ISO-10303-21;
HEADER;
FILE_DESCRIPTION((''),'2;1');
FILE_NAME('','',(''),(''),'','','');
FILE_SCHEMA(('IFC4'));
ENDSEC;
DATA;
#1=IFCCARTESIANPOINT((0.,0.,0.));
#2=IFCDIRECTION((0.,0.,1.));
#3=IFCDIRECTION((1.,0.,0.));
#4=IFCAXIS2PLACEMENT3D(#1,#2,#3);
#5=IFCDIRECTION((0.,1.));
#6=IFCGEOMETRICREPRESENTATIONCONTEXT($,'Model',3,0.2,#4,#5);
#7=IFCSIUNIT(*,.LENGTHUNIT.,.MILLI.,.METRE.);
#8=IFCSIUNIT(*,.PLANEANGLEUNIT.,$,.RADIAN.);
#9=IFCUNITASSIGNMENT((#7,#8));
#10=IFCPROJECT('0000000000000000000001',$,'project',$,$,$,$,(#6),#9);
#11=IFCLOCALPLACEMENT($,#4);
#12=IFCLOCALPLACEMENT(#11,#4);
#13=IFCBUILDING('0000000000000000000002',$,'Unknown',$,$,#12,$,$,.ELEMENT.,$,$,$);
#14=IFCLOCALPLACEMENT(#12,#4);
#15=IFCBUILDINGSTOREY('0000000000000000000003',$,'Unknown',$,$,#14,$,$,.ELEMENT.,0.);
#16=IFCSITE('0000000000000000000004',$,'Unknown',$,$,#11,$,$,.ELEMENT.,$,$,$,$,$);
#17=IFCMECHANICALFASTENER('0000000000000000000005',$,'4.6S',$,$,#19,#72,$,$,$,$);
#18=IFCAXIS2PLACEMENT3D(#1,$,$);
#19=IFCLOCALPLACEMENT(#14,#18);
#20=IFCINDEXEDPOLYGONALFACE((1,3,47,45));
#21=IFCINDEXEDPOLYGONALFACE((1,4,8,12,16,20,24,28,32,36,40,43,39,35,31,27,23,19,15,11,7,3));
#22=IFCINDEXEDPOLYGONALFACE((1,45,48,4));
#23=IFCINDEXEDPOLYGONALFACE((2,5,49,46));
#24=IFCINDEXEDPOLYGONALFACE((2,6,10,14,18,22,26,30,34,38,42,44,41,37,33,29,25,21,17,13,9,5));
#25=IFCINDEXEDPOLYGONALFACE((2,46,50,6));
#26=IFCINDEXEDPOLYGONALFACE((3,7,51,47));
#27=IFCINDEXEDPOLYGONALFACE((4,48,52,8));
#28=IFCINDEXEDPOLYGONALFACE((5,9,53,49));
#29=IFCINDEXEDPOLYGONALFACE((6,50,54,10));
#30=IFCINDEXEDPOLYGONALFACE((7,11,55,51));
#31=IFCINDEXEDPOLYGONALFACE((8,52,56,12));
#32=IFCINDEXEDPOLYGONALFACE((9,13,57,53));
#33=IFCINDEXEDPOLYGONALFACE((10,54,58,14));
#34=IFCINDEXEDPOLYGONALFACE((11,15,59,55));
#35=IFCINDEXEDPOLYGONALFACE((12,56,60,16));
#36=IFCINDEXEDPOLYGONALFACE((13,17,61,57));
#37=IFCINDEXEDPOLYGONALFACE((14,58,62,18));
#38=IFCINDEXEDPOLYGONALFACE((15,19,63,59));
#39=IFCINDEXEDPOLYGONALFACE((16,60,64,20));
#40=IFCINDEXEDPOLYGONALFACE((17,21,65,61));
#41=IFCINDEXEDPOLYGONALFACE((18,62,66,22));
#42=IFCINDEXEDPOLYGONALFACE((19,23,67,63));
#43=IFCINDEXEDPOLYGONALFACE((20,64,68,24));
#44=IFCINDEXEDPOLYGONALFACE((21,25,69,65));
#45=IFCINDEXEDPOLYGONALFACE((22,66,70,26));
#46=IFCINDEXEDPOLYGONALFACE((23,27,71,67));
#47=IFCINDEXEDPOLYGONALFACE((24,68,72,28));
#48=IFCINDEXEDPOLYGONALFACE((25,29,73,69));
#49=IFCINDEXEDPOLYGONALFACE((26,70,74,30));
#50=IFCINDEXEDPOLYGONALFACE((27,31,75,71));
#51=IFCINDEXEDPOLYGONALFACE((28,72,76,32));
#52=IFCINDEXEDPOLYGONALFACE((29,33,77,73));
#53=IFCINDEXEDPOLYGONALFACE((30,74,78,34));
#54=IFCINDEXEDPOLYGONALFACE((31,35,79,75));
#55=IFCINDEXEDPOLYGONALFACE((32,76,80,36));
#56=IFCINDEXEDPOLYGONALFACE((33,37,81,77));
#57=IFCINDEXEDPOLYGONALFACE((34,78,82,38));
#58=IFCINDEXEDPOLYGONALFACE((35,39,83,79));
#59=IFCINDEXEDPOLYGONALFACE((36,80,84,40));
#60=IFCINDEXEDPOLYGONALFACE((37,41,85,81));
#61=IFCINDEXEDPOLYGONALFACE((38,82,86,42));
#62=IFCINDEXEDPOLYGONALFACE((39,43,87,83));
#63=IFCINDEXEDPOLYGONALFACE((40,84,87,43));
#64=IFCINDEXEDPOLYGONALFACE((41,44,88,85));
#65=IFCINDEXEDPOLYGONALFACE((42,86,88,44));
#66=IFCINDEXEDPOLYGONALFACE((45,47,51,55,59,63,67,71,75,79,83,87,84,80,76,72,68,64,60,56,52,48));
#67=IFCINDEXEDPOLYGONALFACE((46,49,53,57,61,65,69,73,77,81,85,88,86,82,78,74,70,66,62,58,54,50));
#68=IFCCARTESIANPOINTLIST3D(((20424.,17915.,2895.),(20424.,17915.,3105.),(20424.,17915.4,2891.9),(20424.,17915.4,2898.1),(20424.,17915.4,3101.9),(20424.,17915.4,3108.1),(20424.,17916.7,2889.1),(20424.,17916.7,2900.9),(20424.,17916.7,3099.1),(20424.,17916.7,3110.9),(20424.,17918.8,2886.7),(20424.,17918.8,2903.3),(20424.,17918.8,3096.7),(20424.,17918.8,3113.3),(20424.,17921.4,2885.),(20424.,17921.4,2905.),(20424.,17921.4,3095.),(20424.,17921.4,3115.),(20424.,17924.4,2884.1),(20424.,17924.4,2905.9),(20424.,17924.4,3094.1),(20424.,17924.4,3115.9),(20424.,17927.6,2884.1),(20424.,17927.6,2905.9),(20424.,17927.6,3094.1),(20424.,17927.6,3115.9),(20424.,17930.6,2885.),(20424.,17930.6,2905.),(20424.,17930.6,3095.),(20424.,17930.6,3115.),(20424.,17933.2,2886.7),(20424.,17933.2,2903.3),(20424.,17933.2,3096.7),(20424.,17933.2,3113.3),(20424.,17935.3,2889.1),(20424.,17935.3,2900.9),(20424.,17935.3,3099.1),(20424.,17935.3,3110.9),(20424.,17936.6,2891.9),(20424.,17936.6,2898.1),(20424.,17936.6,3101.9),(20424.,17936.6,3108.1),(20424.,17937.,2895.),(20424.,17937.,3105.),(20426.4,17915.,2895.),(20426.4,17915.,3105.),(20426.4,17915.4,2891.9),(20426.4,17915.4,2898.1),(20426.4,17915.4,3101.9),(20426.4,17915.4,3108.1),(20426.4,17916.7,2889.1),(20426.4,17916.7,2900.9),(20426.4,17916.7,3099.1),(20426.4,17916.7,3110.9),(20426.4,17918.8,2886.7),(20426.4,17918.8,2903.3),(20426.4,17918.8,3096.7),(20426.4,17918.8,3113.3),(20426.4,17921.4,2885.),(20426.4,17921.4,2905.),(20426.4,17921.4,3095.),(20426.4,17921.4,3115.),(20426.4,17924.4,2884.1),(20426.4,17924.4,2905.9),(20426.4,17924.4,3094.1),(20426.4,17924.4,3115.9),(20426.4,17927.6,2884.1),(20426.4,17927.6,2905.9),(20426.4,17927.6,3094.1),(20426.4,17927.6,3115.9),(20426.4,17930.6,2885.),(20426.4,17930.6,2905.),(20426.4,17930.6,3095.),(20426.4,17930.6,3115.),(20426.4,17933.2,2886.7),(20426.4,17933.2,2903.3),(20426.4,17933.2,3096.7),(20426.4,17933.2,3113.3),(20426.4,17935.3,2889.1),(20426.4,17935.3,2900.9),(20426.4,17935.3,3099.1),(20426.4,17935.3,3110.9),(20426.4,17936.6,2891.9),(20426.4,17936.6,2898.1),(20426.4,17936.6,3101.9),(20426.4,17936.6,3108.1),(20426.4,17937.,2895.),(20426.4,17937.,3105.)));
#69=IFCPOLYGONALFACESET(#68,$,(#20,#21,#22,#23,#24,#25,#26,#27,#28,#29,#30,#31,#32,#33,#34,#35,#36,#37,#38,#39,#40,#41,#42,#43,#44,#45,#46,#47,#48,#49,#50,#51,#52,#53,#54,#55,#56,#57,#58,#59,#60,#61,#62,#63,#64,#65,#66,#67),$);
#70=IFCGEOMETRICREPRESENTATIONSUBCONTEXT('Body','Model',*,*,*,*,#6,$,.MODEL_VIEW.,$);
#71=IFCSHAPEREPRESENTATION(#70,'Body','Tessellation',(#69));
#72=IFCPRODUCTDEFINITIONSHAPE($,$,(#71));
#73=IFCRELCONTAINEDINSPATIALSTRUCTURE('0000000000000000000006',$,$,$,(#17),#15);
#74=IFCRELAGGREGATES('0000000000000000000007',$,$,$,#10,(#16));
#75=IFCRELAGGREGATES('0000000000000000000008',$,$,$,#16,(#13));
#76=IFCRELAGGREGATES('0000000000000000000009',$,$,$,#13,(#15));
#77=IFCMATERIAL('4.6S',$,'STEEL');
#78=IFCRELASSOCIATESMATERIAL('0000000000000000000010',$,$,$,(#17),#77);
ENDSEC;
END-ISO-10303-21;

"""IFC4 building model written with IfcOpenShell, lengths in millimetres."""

from ifc_helpers import new_model, si_unit, direction, frame, origin_with_axes, place, context, subcontext, project, spatial, arc, indexed_curve, outline, extrude, source, transform, mapped, material, element, save


model = new_model("IFC4")

# Units and contexts
model_context = context("Model", 3, precision=0.2, world=origin_with_axes(), true_north=direction((0.0, 1.0)))
body_context = subcontext(model_context, "Body", "Model", "MODEL_VIEW")
ifc_project = project(units=[si_unit("LENGTHUNIT", "METRE", prefix="MILLI"), si_unit("PLANEANGLEUNIT", "RADIAN")], contexts=[model_context])

# Site, building, storey
site_placement = place(None, origin_with_axes())
site = spatial("IfcSite", under=ifc_project, at=site_placement, Name="Unknown", CompositionType="ELEMENT")
building_placement = place(site_placement, origin_with_axes())
building = spatial("IfcBuilding", under=site, at=building_placement, Name="Unknown", CompositionType="ELEMENT")
storey_placement = place(building_placement, origin_with_axes())
storey = spatial("IfcBuildingStorey", under=building, at=storey_placement, Name="Unknown", CompositionType="ELEMENT", Elevation=0.0)

# Mechanical fastener
ifc_material_1 = material(Name="4.6S", Category="STEEL")
shared_shape_1 = source(origin_with_axes(), body_context, "Body", "SweptSolid", [
    extrude(outline(indexed_curve([(11.0, 0.0), (0.0, 11.0), (-11.0, 0.0), (0.0, -11.0)], segments=[arc(1, 2, 3), arc(3, 4, 1)])), frame((0.0, 0.0, 1.2), z_axis=(0.0, 0.0, -1.0), x_axis=(0.0, 1.0, 0.0)), (0.0, 0.0, 1.0), 2.4),
])
for number, where, z_axis, x_axis, name in (
    (1, (20425.2, 17926.0, 2895.0), (-1.0, 0.0, 0.0), (0.0, 0.0, 1.0), "4.6S"),
):
    element("IfcMechanicalFastener", number, at=place(storey_placement, frame(where, z_axis=z_axis, x_axis=x_axis)), inside=storey, material=ifc_material_1, Name=name, context=body_context, shape_type="MappedRepresentation", body=[
        mapped(shared_shape_1, transform((0.0, 0.0, 0.0))),
        mapped(shared_shape_1, transform((210.0, 0.0, 0.0))),
    ])

save(model, "model.ifc")
